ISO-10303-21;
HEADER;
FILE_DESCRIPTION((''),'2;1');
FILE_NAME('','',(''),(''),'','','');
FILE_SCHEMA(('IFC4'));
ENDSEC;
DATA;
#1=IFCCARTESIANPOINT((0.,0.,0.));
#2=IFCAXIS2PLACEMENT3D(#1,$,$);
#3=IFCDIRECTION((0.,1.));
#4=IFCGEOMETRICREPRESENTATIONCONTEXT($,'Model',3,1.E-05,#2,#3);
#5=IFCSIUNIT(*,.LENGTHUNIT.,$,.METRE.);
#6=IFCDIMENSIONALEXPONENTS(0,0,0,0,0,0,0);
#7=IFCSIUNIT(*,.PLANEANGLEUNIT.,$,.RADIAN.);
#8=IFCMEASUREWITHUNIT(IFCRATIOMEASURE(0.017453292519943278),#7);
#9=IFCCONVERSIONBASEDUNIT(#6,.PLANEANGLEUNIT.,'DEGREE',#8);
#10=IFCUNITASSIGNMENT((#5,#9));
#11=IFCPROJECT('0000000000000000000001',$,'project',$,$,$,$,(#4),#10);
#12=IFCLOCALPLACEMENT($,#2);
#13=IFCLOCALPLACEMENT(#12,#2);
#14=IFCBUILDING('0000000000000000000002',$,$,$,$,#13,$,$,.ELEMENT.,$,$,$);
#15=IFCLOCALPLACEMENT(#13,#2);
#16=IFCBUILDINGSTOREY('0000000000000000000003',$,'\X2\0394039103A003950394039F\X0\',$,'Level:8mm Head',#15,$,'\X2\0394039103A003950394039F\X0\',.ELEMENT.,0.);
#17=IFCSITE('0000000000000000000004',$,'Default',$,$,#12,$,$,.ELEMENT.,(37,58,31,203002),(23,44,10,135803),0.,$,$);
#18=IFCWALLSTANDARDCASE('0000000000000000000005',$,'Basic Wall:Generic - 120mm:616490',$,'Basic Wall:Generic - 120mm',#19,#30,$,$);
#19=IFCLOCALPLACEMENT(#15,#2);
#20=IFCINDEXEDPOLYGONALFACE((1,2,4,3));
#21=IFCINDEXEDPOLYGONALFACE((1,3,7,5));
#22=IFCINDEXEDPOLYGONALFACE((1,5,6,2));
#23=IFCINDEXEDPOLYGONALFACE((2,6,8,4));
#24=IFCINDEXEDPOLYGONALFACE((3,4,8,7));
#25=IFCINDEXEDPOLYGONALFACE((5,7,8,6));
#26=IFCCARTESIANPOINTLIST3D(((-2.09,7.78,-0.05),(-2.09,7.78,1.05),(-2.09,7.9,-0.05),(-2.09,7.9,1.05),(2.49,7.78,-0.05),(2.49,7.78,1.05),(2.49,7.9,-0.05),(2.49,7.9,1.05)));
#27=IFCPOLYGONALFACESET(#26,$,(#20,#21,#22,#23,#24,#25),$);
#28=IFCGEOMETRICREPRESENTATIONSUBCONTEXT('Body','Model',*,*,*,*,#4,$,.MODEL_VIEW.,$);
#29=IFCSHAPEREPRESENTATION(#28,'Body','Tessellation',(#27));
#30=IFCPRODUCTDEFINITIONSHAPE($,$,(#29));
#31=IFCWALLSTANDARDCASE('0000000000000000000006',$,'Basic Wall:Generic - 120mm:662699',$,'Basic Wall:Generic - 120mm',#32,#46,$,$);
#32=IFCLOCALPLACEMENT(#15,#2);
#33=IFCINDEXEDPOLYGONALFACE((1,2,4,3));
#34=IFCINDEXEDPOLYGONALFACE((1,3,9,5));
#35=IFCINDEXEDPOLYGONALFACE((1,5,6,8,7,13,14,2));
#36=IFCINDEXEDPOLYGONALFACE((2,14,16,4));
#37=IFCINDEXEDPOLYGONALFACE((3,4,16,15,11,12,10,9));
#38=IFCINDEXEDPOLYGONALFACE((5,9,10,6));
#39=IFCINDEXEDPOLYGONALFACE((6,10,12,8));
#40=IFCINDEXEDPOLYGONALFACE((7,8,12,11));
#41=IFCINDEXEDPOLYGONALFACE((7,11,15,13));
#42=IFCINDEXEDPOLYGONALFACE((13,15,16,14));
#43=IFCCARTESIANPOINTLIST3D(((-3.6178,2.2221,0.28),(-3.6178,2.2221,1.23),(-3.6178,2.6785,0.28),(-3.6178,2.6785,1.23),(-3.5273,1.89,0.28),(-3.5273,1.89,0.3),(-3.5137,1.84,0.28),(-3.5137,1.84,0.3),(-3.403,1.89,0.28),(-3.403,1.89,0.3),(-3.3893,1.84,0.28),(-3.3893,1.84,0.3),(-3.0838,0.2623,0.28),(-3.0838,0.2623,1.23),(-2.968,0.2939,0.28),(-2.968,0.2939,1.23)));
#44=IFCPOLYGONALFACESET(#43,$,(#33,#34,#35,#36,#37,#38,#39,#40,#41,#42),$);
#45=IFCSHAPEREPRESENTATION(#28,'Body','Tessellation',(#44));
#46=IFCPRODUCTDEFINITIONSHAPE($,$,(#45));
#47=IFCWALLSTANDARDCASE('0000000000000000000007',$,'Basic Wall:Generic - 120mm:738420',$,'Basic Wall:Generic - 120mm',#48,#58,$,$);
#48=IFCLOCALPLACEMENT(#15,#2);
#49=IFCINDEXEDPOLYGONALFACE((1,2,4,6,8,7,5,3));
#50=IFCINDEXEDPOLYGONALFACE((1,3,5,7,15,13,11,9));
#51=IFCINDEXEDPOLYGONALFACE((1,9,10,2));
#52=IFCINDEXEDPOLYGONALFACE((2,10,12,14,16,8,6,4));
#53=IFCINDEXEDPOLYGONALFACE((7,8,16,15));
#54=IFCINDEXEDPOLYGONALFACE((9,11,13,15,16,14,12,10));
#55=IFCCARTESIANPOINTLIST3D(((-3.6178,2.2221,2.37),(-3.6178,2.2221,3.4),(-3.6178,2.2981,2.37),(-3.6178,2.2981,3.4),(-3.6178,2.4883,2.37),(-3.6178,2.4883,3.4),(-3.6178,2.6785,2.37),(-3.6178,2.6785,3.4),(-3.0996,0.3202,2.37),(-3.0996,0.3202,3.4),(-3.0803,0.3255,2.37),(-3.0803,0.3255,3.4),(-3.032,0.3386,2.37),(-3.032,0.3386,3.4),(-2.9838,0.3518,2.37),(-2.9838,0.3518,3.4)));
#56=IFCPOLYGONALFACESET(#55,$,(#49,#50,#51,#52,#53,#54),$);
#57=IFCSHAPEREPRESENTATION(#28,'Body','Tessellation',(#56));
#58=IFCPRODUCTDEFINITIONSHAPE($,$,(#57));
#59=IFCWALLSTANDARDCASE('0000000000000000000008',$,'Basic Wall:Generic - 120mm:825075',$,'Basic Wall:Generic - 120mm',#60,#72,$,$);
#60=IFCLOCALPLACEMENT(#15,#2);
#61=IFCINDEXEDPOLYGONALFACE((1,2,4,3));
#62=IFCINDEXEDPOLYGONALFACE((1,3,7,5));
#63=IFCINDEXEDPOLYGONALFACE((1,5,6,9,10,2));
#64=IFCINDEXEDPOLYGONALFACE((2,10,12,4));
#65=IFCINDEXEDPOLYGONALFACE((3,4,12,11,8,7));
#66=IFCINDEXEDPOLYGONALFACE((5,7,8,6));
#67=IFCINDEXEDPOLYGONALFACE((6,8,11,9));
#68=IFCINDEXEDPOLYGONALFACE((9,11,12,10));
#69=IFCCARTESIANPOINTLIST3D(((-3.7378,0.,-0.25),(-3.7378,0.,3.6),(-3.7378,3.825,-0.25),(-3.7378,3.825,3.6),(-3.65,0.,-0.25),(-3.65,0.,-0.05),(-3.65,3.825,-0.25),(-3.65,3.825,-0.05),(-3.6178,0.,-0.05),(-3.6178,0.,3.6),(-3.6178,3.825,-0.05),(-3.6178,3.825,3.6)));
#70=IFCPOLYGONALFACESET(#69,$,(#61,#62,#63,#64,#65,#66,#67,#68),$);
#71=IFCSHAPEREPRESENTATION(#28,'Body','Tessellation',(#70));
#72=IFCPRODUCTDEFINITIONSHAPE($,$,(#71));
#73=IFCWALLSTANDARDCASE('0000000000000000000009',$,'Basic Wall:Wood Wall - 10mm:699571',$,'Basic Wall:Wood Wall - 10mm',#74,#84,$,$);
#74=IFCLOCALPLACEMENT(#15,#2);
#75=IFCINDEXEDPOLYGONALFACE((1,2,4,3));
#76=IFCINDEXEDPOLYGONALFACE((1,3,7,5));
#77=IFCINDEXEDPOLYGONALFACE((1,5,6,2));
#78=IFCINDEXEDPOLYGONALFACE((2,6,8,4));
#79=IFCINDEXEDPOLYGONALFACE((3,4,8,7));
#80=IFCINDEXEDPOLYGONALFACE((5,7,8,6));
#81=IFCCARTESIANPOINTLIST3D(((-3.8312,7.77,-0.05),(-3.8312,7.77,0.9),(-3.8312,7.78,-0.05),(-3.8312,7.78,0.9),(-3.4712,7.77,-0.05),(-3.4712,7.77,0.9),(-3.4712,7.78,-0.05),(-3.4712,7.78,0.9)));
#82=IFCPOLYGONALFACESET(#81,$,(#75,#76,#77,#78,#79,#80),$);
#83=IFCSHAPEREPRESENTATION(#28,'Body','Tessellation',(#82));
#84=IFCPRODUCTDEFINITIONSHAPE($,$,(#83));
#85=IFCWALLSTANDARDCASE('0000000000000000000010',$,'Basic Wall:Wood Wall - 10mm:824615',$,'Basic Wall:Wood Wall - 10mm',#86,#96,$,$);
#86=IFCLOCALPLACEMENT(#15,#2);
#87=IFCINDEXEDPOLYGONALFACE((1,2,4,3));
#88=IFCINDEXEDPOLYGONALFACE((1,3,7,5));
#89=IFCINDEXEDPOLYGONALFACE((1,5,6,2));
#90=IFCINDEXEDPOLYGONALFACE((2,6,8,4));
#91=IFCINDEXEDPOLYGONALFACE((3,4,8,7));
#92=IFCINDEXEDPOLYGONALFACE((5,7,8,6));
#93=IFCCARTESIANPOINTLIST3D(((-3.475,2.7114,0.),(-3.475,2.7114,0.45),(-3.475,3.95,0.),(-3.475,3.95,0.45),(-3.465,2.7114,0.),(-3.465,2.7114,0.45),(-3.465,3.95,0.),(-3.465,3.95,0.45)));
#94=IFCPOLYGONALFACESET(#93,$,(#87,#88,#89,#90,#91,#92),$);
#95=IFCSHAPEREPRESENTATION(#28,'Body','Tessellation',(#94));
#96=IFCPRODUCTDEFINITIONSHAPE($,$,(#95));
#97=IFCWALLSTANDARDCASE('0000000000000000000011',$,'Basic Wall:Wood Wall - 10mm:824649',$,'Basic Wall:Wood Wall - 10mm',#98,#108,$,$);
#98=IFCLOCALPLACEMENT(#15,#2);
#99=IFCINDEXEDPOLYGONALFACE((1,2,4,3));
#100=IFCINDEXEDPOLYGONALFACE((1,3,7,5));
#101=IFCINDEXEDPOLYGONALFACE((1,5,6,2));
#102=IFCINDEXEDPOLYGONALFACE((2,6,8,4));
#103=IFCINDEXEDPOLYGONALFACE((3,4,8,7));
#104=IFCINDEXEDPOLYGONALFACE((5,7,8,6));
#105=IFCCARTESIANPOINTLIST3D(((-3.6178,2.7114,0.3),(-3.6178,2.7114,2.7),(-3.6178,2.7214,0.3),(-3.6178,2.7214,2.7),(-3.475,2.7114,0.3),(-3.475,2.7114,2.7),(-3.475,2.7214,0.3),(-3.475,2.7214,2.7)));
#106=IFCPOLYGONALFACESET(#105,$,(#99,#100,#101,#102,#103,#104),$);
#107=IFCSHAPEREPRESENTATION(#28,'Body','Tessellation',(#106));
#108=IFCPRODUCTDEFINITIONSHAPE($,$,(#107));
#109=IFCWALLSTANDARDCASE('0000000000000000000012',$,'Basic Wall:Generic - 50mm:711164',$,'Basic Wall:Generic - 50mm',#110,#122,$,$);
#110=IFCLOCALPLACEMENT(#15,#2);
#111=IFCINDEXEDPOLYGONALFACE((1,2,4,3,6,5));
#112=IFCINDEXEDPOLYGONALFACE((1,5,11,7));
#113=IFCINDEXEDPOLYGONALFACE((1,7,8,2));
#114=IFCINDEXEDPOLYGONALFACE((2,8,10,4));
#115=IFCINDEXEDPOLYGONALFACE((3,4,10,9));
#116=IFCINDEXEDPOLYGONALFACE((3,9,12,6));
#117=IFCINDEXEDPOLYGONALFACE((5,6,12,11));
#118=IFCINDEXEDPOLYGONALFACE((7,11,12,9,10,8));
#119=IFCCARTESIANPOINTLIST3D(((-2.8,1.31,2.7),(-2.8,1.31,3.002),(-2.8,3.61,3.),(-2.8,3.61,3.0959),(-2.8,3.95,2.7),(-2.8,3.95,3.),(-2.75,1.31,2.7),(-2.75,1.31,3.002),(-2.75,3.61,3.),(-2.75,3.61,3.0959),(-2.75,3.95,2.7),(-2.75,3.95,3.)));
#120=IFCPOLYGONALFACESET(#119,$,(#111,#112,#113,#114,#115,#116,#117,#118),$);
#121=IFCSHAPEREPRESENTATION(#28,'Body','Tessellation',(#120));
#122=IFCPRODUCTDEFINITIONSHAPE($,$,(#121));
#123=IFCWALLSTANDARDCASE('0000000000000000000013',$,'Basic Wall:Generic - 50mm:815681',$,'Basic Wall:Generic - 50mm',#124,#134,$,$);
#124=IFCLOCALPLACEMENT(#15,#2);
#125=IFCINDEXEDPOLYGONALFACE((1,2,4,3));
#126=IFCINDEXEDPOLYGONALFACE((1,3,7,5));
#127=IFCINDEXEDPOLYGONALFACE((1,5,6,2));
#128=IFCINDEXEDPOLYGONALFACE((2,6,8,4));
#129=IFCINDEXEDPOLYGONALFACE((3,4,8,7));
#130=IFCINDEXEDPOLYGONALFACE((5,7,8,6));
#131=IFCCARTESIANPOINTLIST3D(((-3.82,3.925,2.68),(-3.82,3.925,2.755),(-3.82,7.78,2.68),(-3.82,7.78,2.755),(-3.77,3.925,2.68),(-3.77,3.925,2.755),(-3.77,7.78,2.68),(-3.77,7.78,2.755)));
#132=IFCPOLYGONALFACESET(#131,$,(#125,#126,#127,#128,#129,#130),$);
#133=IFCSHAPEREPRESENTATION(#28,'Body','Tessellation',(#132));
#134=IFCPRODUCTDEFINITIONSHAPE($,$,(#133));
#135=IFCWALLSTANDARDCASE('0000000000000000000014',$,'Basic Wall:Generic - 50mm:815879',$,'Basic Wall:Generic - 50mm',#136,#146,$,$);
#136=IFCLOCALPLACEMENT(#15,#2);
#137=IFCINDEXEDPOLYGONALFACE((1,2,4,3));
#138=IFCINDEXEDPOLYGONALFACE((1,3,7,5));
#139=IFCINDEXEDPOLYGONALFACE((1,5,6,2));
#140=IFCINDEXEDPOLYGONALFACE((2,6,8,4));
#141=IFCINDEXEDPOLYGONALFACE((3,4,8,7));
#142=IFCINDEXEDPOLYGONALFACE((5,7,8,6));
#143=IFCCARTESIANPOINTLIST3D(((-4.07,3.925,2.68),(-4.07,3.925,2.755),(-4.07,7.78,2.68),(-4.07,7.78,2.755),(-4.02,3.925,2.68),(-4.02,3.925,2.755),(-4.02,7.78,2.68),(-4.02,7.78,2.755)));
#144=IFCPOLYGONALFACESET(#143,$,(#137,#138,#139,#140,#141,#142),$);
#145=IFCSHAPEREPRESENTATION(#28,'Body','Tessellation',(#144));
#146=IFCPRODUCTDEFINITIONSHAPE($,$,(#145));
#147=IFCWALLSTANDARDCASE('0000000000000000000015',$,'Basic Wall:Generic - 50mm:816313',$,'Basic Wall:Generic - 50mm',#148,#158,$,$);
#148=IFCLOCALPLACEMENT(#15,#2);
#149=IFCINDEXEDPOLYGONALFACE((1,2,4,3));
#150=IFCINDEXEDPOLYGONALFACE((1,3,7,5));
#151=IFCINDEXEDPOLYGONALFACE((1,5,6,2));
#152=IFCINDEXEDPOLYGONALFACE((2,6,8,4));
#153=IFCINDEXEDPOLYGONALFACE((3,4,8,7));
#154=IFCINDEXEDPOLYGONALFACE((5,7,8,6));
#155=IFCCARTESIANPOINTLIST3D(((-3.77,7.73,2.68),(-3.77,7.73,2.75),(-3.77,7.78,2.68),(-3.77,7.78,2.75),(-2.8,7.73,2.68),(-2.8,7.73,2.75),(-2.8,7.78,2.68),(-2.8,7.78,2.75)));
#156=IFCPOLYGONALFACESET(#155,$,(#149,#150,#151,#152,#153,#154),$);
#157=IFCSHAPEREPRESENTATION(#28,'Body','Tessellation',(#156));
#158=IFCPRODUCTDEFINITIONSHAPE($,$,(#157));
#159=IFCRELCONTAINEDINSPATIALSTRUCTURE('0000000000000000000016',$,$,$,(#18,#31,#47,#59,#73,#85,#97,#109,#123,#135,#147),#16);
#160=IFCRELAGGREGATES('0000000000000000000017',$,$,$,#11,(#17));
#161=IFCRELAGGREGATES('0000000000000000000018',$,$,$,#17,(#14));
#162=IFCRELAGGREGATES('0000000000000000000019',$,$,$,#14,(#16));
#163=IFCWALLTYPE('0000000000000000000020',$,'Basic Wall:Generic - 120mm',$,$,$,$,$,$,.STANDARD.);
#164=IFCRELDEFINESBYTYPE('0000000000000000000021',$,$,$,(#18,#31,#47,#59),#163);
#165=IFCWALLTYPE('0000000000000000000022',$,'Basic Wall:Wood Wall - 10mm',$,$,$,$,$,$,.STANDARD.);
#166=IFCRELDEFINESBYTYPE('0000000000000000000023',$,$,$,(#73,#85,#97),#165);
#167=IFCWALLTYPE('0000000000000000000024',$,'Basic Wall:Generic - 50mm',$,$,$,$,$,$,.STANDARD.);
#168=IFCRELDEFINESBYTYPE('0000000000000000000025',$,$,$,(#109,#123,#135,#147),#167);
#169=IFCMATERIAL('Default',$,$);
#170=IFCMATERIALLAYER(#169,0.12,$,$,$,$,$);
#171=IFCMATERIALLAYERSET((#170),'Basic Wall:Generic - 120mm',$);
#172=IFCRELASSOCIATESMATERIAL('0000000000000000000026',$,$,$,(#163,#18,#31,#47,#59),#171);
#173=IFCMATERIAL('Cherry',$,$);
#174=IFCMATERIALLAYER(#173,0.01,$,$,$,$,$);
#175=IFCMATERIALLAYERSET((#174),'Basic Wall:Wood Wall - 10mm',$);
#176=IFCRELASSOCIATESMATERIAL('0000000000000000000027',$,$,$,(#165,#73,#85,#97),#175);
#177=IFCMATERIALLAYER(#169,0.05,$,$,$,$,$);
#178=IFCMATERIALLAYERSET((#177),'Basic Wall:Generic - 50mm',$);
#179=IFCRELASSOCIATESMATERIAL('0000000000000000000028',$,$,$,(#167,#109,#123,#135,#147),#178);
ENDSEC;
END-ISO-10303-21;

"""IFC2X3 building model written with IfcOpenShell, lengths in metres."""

from ifc_helpers import new_model, entity, si_unit, converted_unit, direction, frame, frame_2d, origin, place, context, subcontext, project, spatial, polyline, rectangle, outline, extrude, clip, bounded_halfspace, material, layer, layer_set, layer_usage, type_object, element, save


model = new_model("IFC2X3")

# Units and contexts
model_context = context("Model", 3, precision=1e-05, world=origin(), true_north=direction((0.0, 1.0)))
body_context = subcontext(model_context, "Body", "Model", "MODEL_VIEW")
ifc_project = project(units=[si_unit("LENGTHUNIT", "METRE"), converted_unit("PLANEANGLEUNIT", "DEGREE", entity("IfcRatioMeasure", 0.017453292519943278), si_unit("PLANEANGLEUNIT", "RADIAN"), dimensions=[0, 0, 0, 0, 0, 0, 0])], contexts=[model_context])

# Site, building, storey
site_placement = place(None, origin())
site = spatial("IfcSite", under=ifc_project, at=site_placement, Name="Default", CompositionType="ELEMENT", RefLatitude=(37, 58, 31, 203002), RefLongitude=(23, 44, 10, 135803), RefElevation=0.0)
building_placement = place(site_placement, origin())
building = spatial("IfcBuilding", under=site, at=building_placement, CompositionType="ELEMENT")
storey_placement = place(building_placement, origin())
storey = spatial("IfcBuildingStorey", under=building, at=storey_placement, Name="ΔΑΠΕΔΟ", ObjectType="Level:8mm Head", LongName="ΔΑΠΕΔΟ", CompositionType="ELEMENT", Elevation=0.0)

# Walls
ifc_material_1 = material(Name="Default")
ifc_layer_1 = layer(ifc_material_1, 0.12)
ifc_layer_set_1 = layer_set([ifc_layer_1], Name="Basic Wall:Generic - 120mm")
ifc_layer_usage_1 = layer_usage(ifc_layer_set_1, "AXIS2", "POSITIVE", -0.06)
wall_type_1 = type_object("IfcWallType", Name="Basic Wall:Generic - 120mm", PredefinedType="STANDARD", material=ifc_layer_set_1)
wall_1_placement = place(storey_placement, frame((-2.09, 7.84, -0.05)))
element("IfcWallStandardCase", 1, at=wall_1_placement, inside=storey, type_object=wall_type_1, material=ifc_layer_usage_1, Name="Basic Wall:Generic - 120mm:616490", ObjectType="Basic Wall:Generic - 120mm", context=body_context, shape_type="SweptSolid", body=[
    extrude(rectangle(XDim=4.58, YDim=0.12, at=frame_2d((2.29, 0.0), x_axis=(-1.0, 0.0))), origin(), (0.0, 0.0, 1.0), 1.1),
])
ifc_layer_usage_2 = layer_usage(ifc_layer_set_1, "AXIS2", "NEGATIVE", 0.06)
wall_2_placement = place(storey_placement, frame((-3.6757, 2.6627, 0.28), z_axis=(0.0, 0.0, 1.0), x_axis=(0.262929, -0.964815, 0.0)))
element("IfcWallStandardCase", 2, at=wall_2_placement, inside=storey, type_object=wall_type_1, material=ifc_layer_usage_2, Name="Basic Wall:Generic - 120mm:662699", ObjectType="Basic Wall:Generic - 120mm", context=body_context, shape_type="Clipping", body=[
    clip(extrude(outline(polyline([(0.4403, -0.06), (2.3515, -0.06), (2.4715, -0.06), (2.4715, 0.06), (0.0, 0.06), (0.1835, 0.01), (0.3669, -0.04), (0.4403, -0.06)])), origin(), (0.0, 0.0, 1.0), 0.95), bounded_halfspace(frame((0.8691, 0.06, 0.02), z_axis=(0.0, 0.0, 1.0), x_axis=(-0.964815, 0.262929, 0.0)), True, frame((0.8691, 0.06, 0.02), z_axis=(0.0, 0.0, 1.0), x_axis=(-0.964815, 0.262929, 0.0)), polyline([(0.0, 0.0), (0.05, 0.0136), (0.05, 0.138), (0.0, 0.1244), (0.0, 0.0)]))),
])
wall_3_placement = place(storey_placement, frame((-3.6757, 2.6627, 2.37), z_axis=(0.0, 0.0, 1.0), x_axis=(0.262929, -0.964815, 0.0)))
element("IfcWallStandardCase", 3, at=wall_3_placement, inside=storey, type_object=wall_type_1, material=ifc_layer_usage_2, Name="Basic Wall:Generic - 120mm:738420", ObjectType="Basic Wall:Generic - 120mm", context=body_context, shape_type="SweptSolid", body=[
    extrude(outline(polyline([(2.4115, -0.06), (2.4115, -0.04), (2.4115, 0.01), (2.4115, 0.06), (0.0, 0.06), (0.1835, 0.01), (0.3669, -0.04), (0.4403, -0.06), (2.4115, -0.06)])), origin(), (0.0, 0.0, 1.0), 1.03),
])
wall_4_placement = place(storey_placement, frame((-3.6778, 3.825, -0.25), z_axis=(0.0, 0.0, 1.0), x_axis=(0.0, -1.0, 0.0)))
element("IfcWallStandardCase", 4, at=wall_4_placement, inside=storey, type_object=wall_type_1, material=ifc_layer_usage_2, Name="Basic Wall:Generic - 120mm:825075", ObjectType="Basic Wall:Generic - 120mm", context=body_context, shape_type="Clipping", body=[
    clip(clip(extrude(rectangle(XDim=3.825, YDim=0.12, at=frame_2d((1.9125, 0.0), x_axis=(-1.0, 0.0))), origin(), (0.0, 0.0, 1.0), 3.85), bounded_halfspace(frame((3.825, 0.0278, 0.2), z_axis=(0.0, 0.0, 1.0), x_axis=(-1.0, 0.0, 0.0)), True, frame((3.825, 0.0278, 0.2), z_axis=(0.0, 0.0, 1.0), x_axis=(-1.0, 0.0, 0.0)), polyline([(0.0, 0.0), (0.0, -0.0322), (1.84, -0.0322), (1.89, -0.0322), (3.825, -0.0322), (3.825, 0.0), (0.0, 0.0)]))), bounded_halfspace(frame((0.0, 0.0278, 0.2), z_axis=(0.0, -1.0, 0.0), x_axis=(0.0, 0.0, 1.0)), True, frame((0.0, 0.0278, 0.2), z_axis=(0.0, -1.0, 0.0), x_axis=(0.0, 0.0, 1.0)), polyline([(0.0, 0.0), (-0.2, 0.0), (-0.2, -3.825), (0.0, -3.825), (0.0, 0.0)]))),
])
ifc_material_2 = material(Name="Cherry")
ifc_layer_2 = layer(ifc_material_2, 0.01)
ifc_layer_set_2 = layer_set([ifc_layer_2], Name="Basic Wall:Wood Wall - 10mm")
ifc_layer_usage_3 = layer_usage(ifc_layer_set_2, "AXIS2", "NEGATIVE", 0.005)
wall_type_2 = type_object("IfcWallType", Name="Basic Wall:Wood Wall - 10mm", PredefinedType="STANDARD", material=ifc_layer_set_2)
wall_5_placement = place(storey_placement, frame((-3.4712, 7.775, -0.05), z_axis=(0.0, 0.0, 1.0), x_axis=(-1.0, 0.0, 0.0)))
element("IfcWallStandardCase", 5, at=wall_5_placement, inside=storey, type_object=wall_type_2, material=ifc_layer_usage_3, Name="Basic Wall:Wood Wall - 10mm:699571", ObjectType="Basic Wall:Wood Wall - 10mm", context=body_context, shape_type="Clipping", body=[
    clip(extrude(rectangle(XDim=0.36, YDim=0.01, at=frame_2d((0.18, 0.0), x_axis=(-1.0, 0.0))), origin(), (0.0, 0.0, 1.0), 0.95), bounded_halfspace(frame((0.36, -0.005, 0.0), z_axis=(0.0, 0.0, 1.0), x_axis=(0.0, -1.0, 0.0)), True, frame((0.36, -0.005, 0.0), z_axis=(0.0, 0.0, 1.0), x_axis=(0.0, -1.0, 0.0)), polyline([(0.0, 0.0), (-0.01, 0.0), (-0.01, -0.36), (0.0, -0.36), (0.0, 0.0)]))),
])
ifc_layer_usage_4 = layer_usage(ifc_layer_set_2, "AXIS2", "POSITIVE", -0.005)
wall_6_placement = place(storey_placement, frame((-3.47, 3.95, 0.0), z_axis=(0.0, 0.0, 1.0), x_axis=(0.0, -1.0, 0.0)))
element("IfcWallStandardCase", 6, at=wall_6_placement, inside=storey, type_object=wall_type_2, material=ifc_layer_usage_4, Name="Basic Wall:Wood Wall - 10mm:824615", ObjectType="Basic Wall:Wood Wall - 10mm", context=body_context, shape_type="SweptSolid", body=[
    extrude(rectangle(XDim=1.2386, YDim=0.01, at=frame_2d((0.6193, 0.0), x_axis=(-1.0, 0.0))), origin(), (0.0, 0.0, 1.0), 0.45),
])
wall_7_placement = place(storey_placement, frame((-3.475, 2.7164, 0.3), z_axis=(0.0, 0.0, 1.0), x_axis=(-1.0, 0.0, 0.0)))
element("IfcWallStandardCase", 7, at=wall_7_placement, inside=storey, type_object=wall_type_2, material=ifc_layer_usage_4, Name="Basic Wall:Wood Wall - 10mm:824649", ObjectType="Basic Wall:Wood Wall - 10mm", context=body_context, shape_type="SweptSolid", body=[
    extrude(rectangle(XDim=0.1428, YDim=0.01, at=frame_2d((0.0714, 0.0), x_axis=(-1.0, 0.0))), origin(), (0.0, 0.0, 1.0), 2.4),
])
ifc_layer_3 = layer(ifc_material_1, 0.05)
ifc_layer_set_3 = layer_set([ifc_layer_3], Name="Basic Wall:Generic - 50mm")
ifc_layer_usage_5 = layer_usage(ifc_layer_set_3, "AXIS2", "NEGATIVE", 0.025)
wall_type_3 = type_object("IfcWallType", Name="Basic Wall:Generic - 50mm", PredefinedType="STANDARD", material=ifc_layer_set_3)
wall_8_placement = place(storey_placement, frame((-2.775, 3.95, 2.7), z_axis=(0.0, 0.0, 1.0), x_axis=(0.0, -1.0, 0.0)))
element("IfcWallStandardCase", 8, at=wall_8_placement, inside=storey, type_object=wall_type_3, material=ifc_layer_usage_5, Name="Basic Wall:Generic - 50mm:711164", ObjectType="Basic Wall:Generic - 50mm", context=body_context, shape_type="Clipping", body=[
    clip(clip(clip(extrude(rectangle(XDim=2.64, YDim=0.05, at=frame_2d((1.32, 0.0), x_axis=(-1.0, 0.0))), origin(), (0.0, 0.0, 1.0), 0.3959), bounded_halfspace(frame((0.34, -0.025, 0.3959), z_axis=(-0.040782, 0.0, -0.999168), x_axis=(-0.999168, 0.0, 0.040782)), True, frame((0.34, -0.025, 0.3959)), polyline([(0.0, 0.0), (2.3, 0.0), (2.3, 0.05), (0.0, 0.05), (0.0, 0.0)]))), bounded_halfspace(frame((0.0, -0.025, 0.3), z_axis=(0.0, 0.0, -1.0), x_axis=(0.0, 1.0, 0.0)), True, frame((0.0, -0.025, 0.3)), polyline([(0.0, 0.0), (0.34, 0.0), (0.34, 0.05), (0.0, 0.05), (0.0, 0.0)]))), bounded_halfspace(frame((0.0, -0.025, 0.3), z_axis=(0.0, 0.0, -1.0), x_axis=(0.0, 1.0, 0.0)), True, frame((0.0, -0.025, 0.3)), polyline([(0.0, 0.0), (0.34, 0.0), (0.34, 0.05), (0.0, 0.05), (0.0, 0.0)]))),
])
wall_9_placement = place(storey_placement, frame((-3.795, 3.925, 2.68), z_axis=(0.0, 0.0, 1.0), x_axis=(0.0, 1.0, 0.0)))
element("IfcWallStandardCase", 9, at=wall_9_placement, inside=storey, type_object=wall_type_3, material=ifc_layer_usage_5, Name="Basic Wall:Generic - 50mm:815681", ObjectType="Basic Wall:Generic - 50mm", context=body_context, shape_type="SweptSolid", body=[
    extrude(rectangle(XDim=3.855, YDim=0.05, at=frame_2d((1.9275, 0.0), x_axis=(-1.0, 0.0))), origin(), (0.0, 0.0, 1.0), 0.075),
])
wall_10_placement = place(storey_placement, frame((-4.045, 3.925, 2.68), z_axis=(0.0, 0.0, 1.0), x_axis=(0.0, 1.0, 0.0)))
element("IfcWallStandardCase", 10, at=wall_10_placement, inside=storey, type_object=wall_type_3, material=ifc_layer_usage_5, Name="Basic Wall:Generic - 50mm:815879", ObjectType="Basic Wall:Generic - 50mm", context=body_context, shape_type="SweptSolid", body=[
    extrude(rectangle(XDim=3.855, YDim=0.05, at=frame_2d((1.9275, 0.0), x_axis=(-1.0, 0.0))), origin(), (0.0, 0.0, 1.0), 0.075),
])
ifc_layer_usage_6 = layer_usage(ifc_layer_set_3, "AXIS2", "POSITIVE", -0.025)
wall_11_placement = place(storey_placement, frame((-2.8, 7.755, 2.68), z_axis=(0.0, 0.0, 1.0), x_axis=(-1.0, 0.0, 0.0)))
element("IfcWallStandardCase", 11, at=wall_11_placement, inside=storey, type_object=wall_type_3, material=ifc_layer_usage_6, Name="Basic Wall:Generic - 50mm:816313", ObjectType="Basic Wall:Generic - 50mm", context=body_context, shape_type="Clipping", body=[
    clip(clip(extrude(rectangle(XDim=0.97, YDim=0.05, at=frame_2d((0.485, 0.0), x_axis=(-1.0, 0.0))), origin(), (0.0, 0.0, 1.0), 0.07), bounded_halfspace(frame((0.97, -0.025, 0.0), z_axis=(0.0, 0.0, 1.0), x_axis=(0.0, 1.0, 0.0)), True, frame((0.97, -0.025, 0.0), z_axis=(0.0, 0.0, 1.0), x_axis=(0.0, 1.0, 0.0)), polyline([(0.0, 0.0), (0.05, 0.0), (0.05, 0.97), (0.0, 0.97), (0.0, 0.0)]))), bounded_halfspace(frame((0.0, -0.025, 0.07), z_axis=(0.0, 0.0, -1.0), x_axis=(-1.0, 0.0, 0.0)), True, frame((0.0, -0.025, 0.07), z_axis=(0.0, 0.0, -1.0), x_axis=(-1.0, 0.0, 0.0)), polyline([(0.0, 0.0), (0.0, 0.05), (-0.97, 0.05), (-0.97, 0.0), (-0.6713, 0.0), (0.0, 0.0)]))),
])

save(model, "model.ifc")
